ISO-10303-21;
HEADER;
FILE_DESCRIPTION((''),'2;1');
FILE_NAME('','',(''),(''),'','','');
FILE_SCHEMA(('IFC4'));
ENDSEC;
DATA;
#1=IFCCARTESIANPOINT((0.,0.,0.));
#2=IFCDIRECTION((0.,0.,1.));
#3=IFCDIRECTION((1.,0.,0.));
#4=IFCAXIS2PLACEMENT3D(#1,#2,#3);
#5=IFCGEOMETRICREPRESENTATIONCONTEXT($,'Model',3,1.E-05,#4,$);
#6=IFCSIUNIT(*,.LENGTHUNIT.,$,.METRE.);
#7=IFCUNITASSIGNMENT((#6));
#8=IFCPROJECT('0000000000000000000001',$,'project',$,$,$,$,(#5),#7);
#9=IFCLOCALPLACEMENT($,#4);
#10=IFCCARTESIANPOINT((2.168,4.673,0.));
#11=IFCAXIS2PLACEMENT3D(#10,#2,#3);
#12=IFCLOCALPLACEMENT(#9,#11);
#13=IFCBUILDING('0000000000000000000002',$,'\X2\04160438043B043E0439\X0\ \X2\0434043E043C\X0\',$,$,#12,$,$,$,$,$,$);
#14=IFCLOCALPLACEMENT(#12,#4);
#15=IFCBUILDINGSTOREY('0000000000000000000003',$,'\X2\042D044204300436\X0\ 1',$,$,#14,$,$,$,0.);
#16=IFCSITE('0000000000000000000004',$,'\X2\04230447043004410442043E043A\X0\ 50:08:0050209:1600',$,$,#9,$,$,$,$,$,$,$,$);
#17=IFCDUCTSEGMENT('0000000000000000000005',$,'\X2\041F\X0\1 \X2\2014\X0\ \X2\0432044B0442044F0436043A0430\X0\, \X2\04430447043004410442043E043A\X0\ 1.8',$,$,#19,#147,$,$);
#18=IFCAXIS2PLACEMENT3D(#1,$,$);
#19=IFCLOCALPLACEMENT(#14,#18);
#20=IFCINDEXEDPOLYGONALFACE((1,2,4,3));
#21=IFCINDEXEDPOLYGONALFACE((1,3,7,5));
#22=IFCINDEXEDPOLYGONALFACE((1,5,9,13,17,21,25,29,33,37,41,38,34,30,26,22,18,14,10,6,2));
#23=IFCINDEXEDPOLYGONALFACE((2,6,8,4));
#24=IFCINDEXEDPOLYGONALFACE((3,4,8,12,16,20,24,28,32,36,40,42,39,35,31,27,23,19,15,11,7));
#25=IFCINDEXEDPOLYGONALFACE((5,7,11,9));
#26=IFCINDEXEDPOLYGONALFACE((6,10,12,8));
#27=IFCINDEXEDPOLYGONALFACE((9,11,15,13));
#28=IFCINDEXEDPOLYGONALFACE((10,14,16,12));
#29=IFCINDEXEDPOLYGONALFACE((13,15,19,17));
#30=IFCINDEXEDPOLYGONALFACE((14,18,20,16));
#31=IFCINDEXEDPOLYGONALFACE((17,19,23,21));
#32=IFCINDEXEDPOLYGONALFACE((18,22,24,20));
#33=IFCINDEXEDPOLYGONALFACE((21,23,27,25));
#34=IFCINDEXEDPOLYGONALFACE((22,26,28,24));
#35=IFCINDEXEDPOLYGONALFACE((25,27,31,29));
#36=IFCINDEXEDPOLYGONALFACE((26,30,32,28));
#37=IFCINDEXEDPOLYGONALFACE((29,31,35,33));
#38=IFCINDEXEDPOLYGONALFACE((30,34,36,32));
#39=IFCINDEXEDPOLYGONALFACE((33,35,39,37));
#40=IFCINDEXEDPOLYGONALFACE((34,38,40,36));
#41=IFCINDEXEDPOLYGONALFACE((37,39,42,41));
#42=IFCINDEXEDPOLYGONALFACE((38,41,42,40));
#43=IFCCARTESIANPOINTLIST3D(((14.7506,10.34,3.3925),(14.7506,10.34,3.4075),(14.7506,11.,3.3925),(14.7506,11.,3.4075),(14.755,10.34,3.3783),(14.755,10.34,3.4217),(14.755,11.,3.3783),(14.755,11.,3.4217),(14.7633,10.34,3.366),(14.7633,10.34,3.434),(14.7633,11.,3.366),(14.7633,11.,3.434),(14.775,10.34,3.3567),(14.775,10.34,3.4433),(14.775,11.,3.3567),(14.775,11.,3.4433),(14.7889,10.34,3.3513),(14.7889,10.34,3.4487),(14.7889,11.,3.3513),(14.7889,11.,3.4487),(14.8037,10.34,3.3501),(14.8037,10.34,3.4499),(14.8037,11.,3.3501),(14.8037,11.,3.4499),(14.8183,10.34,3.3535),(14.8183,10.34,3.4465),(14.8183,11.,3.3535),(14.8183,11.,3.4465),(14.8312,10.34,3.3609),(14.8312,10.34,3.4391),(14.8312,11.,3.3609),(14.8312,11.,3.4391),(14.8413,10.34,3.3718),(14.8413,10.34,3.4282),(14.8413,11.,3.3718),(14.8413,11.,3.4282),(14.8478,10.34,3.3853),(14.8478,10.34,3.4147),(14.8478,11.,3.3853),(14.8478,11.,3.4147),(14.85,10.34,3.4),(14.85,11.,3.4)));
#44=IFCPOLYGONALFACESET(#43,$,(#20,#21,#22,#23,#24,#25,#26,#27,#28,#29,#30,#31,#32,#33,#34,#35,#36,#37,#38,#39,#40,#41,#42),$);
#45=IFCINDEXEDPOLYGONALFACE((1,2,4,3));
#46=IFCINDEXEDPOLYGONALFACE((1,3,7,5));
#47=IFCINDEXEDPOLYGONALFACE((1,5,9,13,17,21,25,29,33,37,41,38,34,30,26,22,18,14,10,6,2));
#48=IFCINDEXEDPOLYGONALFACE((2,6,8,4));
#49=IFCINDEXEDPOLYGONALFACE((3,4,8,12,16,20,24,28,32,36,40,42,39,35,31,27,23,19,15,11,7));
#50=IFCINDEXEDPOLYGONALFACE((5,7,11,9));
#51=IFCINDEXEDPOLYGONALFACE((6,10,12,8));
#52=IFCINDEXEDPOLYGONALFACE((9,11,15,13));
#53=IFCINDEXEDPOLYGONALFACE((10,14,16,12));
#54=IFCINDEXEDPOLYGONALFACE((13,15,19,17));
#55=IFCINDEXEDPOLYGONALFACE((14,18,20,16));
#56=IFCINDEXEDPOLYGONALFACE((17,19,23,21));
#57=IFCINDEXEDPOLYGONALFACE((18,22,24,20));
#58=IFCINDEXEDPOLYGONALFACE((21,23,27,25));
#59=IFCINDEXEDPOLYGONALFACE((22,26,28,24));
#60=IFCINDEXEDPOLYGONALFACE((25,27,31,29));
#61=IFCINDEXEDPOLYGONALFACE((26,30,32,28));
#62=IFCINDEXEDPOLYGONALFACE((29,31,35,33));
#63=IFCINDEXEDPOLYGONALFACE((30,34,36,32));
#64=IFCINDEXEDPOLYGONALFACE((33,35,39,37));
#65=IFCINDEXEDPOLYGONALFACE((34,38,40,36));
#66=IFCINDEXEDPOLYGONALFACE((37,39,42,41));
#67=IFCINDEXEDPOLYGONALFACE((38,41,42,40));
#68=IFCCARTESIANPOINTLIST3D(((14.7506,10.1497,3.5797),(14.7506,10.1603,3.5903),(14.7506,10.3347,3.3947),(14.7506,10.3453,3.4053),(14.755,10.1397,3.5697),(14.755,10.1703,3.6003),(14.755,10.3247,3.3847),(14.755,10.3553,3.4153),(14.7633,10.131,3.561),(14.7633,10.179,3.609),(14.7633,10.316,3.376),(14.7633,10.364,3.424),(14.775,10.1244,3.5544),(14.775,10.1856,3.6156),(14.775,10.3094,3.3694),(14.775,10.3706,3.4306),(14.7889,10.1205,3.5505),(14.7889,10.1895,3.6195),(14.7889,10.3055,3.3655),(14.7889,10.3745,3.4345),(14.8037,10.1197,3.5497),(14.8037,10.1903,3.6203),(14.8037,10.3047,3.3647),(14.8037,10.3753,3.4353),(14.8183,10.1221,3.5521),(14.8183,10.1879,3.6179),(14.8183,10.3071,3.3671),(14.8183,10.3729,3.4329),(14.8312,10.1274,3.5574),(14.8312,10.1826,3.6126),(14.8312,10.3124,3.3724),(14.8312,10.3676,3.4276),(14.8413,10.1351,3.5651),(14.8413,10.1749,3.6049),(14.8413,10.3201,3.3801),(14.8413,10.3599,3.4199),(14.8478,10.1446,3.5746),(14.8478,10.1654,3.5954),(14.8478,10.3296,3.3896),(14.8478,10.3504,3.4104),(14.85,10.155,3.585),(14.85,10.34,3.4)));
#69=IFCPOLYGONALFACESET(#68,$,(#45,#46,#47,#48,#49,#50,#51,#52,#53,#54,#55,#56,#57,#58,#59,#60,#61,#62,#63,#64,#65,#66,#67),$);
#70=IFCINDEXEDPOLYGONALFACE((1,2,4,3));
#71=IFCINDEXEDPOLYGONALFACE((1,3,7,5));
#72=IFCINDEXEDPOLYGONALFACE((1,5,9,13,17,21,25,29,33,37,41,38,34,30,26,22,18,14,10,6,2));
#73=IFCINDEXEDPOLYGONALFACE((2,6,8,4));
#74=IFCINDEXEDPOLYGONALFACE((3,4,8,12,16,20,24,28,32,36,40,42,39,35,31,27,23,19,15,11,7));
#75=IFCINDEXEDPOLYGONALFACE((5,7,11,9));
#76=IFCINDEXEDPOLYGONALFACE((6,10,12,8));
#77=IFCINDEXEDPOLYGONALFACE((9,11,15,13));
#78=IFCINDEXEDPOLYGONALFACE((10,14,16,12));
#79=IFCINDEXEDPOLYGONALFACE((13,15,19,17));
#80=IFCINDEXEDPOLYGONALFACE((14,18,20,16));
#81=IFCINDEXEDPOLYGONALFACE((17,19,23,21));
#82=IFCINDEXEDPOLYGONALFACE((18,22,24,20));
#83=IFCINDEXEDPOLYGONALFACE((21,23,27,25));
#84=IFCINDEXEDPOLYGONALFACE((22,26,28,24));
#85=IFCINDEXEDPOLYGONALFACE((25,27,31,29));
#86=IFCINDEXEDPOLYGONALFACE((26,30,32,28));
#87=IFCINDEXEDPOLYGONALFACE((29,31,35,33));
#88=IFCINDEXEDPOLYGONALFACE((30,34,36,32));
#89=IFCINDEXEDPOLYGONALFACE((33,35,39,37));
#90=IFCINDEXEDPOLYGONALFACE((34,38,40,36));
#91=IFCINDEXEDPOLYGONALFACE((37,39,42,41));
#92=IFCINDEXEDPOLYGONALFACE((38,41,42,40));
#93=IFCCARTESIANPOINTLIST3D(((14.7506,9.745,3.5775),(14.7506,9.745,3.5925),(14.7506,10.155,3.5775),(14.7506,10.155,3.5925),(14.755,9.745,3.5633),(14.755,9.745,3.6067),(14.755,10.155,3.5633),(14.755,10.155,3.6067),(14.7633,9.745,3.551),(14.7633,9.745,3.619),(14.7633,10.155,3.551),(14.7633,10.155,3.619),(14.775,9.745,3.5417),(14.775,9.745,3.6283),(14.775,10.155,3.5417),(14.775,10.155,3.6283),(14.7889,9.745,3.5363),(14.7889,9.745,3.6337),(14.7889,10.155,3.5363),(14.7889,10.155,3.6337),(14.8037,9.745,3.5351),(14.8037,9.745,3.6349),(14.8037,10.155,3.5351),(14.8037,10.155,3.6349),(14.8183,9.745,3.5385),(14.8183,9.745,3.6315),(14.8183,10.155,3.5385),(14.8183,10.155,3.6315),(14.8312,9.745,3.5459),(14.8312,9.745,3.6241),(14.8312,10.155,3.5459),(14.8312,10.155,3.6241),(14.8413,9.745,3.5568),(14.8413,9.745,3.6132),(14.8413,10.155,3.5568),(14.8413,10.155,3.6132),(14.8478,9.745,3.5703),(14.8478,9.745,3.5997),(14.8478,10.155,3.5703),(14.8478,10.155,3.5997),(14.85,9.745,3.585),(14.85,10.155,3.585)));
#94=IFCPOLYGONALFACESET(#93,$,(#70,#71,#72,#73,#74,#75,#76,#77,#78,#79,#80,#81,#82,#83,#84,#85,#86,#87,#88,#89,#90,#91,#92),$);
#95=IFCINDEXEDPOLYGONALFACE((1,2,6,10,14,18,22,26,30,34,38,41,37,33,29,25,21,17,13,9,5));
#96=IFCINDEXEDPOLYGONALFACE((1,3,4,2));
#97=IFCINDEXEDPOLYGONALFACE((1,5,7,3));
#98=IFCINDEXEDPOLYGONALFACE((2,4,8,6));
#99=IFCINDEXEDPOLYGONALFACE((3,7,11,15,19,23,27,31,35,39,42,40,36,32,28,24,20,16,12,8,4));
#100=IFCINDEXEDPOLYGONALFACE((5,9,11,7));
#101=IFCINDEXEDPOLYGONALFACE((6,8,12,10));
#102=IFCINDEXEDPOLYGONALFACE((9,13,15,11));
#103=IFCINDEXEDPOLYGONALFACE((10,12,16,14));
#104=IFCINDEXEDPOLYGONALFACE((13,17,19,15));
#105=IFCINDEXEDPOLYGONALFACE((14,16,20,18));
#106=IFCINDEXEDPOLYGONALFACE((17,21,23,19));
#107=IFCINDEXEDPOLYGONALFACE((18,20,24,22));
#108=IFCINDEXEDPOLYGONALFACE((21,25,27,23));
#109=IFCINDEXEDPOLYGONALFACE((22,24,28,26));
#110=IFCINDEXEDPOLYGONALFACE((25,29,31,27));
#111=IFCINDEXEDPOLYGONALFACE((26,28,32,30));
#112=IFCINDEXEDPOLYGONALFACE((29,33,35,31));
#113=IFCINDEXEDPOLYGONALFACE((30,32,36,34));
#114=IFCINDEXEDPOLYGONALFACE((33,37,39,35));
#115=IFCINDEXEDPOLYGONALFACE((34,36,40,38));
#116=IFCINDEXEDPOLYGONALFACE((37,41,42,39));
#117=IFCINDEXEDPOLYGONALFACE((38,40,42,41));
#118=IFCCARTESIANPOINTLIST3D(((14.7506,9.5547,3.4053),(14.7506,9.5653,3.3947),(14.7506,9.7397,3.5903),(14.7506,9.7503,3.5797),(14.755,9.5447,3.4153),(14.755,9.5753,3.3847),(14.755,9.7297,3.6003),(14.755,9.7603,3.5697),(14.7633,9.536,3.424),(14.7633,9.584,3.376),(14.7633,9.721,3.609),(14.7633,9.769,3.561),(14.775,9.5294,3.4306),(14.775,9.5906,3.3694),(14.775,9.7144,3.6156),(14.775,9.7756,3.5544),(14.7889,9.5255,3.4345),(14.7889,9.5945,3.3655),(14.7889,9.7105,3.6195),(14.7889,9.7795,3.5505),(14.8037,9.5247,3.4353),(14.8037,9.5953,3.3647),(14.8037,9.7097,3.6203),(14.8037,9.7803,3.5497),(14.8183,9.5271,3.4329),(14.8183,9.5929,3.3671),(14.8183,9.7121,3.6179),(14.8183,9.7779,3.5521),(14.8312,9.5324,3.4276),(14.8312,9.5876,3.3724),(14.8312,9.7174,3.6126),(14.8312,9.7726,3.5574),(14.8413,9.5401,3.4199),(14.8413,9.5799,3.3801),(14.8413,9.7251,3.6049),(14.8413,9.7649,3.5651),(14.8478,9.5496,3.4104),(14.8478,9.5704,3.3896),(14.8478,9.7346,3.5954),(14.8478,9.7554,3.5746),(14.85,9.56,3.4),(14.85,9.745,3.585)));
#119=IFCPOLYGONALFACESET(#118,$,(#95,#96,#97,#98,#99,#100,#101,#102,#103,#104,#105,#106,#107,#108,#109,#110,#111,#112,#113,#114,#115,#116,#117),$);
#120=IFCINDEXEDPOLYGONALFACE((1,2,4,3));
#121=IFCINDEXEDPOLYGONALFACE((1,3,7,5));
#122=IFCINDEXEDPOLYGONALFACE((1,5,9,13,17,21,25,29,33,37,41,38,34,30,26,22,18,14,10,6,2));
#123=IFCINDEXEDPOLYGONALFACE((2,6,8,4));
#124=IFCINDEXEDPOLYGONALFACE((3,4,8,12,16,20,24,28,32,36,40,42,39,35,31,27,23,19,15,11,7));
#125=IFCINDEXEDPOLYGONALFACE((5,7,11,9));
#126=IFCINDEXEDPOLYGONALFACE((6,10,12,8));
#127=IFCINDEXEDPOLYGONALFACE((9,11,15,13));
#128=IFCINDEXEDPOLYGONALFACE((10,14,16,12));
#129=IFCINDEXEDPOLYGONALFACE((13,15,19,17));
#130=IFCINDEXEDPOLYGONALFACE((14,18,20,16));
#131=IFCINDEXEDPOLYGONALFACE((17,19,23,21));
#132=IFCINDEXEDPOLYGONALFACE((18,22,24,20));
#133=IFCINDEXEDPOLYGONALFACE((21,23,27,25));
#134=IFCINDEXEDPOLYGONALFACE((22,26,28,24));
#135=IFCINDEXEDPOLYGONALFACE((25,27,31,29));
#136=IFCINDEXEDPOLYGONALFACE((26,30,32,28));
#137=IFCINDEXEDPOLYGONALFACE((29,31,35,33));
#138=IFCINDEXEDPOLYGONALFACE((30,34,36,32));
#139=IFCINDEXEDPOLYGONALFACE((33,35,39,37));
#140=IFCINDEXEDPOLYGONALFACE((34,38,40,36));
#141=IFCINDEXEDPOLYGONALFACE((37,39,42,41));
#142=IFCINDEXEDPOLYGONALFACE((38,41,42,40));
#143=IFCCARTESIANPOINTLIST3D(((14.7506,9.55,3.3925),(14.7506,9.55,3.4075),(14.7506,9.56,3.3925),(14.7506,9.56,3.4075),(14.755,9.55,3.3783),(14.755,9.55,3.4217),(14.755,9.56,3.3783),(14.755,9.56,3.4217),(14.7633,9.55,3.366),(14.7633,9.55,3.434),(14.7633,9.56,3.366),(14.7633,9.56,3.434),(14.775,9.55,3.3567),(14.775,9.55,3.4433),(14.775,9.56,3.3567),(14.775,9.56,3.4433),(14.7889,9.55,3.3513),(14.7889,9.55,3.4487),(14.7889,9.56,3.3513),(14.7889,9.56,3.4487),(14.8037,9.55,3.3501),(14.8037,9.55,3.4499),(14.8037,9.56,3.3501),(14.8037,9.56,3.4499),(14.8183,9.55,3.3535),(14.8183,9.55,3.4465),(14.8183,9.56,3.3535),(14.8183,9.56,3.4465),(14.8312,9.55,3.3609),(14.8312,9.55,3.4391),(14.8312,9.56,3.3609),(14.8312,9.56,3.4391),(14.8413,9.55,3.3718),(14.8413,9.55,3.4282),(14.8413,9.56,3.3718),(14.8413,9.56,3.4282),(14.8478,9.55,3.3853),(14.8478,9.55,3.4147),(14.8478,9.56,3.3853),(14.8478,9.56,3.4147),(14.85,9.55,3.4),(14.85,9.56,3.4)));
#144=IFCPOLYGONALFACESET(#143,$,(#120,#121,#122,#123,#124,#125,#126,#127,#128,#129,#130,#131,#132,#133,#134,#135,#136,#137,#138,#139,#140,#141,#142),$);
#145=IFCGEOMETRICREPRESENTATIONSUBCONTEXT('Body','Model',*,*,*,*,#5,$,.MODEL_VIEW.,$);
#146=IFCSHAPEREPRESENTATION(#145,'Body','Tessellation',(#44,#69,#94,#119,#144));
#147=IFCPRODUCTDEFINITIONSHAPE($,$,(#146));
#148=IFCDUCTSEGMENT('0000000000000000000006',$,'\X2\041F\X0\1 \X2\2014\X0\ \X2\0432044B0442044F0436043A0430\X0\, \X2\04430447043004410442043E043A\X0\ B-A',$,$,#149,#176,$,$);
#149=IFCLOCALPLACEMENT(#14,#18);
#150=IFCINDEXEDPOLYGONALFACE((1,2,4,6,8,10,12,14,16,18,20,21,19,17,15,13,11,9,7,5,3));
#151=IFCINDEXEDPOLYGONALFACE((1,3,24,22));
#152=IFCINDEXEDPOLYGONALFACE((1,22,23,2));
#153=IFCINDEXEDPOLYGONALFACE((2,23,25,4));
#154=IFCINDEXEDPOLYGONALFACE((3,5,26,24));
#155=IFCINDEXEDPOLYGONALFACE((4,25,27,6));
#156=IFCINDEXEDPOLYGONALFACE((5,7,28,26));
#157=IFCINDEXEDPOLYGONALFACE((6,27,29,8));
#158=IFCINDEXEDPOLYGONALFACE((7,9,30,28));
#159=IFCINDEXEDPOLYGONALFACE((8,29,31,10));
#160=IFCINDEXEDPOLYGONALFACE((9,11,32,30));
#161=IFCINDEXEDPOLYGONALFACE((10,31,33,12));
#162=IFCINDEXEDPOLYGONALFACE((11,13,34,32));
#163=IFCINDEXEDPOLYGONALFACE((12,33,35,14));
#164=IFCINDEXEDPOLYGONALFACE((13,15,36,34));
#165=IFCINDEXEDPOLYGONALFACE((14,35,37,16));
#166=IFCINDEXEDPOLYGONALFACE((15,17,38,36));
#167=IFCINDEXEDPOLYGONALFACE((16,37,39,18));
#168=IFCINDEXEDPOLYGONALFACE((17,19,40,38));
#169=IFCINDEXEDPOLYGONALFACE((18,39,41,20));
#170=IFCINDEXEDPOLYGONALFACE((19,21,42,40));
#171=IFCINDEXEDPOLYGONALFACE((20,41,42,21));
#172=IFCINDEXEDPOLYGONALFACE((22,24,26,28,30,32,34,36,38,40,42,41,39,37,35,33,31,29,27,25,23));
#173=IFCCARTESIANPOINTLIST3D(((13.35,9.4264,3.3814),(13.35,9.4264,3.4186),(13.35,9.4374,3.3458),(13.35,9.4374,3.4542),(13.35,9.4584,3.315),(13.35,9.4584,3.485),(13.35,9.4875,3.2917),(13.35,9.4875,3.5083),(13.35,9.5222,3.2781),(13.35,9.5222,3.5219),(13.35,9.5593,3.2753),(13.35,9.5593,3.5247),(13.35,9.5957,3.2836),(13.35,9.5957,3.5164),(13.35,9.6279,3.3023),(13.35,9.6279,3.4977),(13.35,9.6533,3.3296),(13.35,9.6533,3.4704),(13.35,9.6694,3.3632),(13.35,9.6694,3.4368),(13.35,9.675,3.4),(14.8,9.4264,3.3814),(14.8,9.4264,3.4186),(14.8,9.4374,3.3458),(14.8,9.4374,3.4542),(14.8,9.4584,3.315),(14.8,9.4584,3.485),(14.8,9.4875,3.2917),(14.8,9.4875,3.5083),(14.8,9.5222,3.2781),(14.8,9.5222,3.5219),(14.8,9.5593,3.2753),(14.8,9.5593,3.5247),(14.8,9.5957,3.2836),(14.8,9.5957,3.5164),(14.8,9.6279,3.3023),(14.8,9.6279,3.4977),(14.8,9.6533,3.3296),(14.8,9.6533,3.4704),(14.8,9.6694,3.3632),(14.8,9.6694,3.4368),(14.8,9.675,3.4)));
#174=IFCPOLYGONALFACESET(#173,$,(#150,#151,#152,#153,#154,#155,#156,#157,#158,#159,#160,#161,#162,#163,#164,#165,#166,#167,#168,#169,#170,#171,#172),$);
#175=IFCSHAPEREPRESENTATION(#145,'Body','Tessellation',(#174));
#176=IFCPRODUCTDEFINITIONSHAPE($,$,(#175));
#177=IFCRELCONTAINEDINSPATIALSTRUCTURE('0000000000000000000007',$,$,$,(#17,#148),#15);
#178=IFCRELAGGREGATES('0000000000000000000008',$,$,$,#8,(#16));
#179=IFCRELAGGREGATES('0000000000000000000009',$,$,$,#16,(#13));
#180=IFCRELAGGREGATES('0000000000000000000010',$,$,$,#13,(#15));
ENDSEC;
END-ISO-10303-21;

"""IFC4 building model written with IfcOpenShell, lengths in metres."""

from ifc_helpers import new_model, si_unit, frame, origin_with_axes, origin_2d, place, context, subcontext, project, spatial, circle, extrude, element, save


model = new_model("IFC4")

# Units and contexts
model_context = context("Model", 3, precision=1e-05, world=origin_with_axes())
body_context = subcontext(model_context, "Body", "Model", "MODEL_VIEW")
ifc_project = project(units=[si_unit("LENGTHUNIT", "METRE")], contexts=[model_context])

# Site, building, storey
site_placement = place(None, origin_with_axes())
site = spatial("IfcSite", under=ifc_project, at=site_placement, Name="Участок 50:08:0050209:1600")
building_placement = place(site_placement, frame((2.168, 4.673, 0.0), z_axis=(0.0, 0.0, 1.0), x_axis=(1.0, 0.0, 0.0)))
building = spatial("IfcBuilding", under=site, at=building_placement, Name="Жилой дом")
storey_placement = place(building_placement, origin_with_axes())
storey = spatial("IfcBuildingStorey", under=building, at=storey_placement, Name="Этаж 1", Elevation=0.0)

# Duct segments
duct_segment_1_placement = place(storey_placement, origin_with_axes())
element("IfcDuctSegment", 1, at=duct_segment_1_placement, inside=storey, Name="П1 — вытяжка, участок 1.8", context=body_context, shape_type="SweptSolid", body=[
    extrude(circle(Radius=0.05, at=origin_2d()), frame((14.8, 11.0, 3.4), z_axis=(0.0, -1.0, 0.0), x_axis=(1.0, 0.0, 0.0)), (0.0, 0.0, 1.0), 0.66),
    extrude(circle(Radius=0.05, at=origin_2d()), frame((14.8, 10.34, 3.4), z_axis=(0.0, -0.707107, 0.707107), x_axis=(1.0, 0.0, 0.0)), (0.0, 0.0, 1.0), 0.2616),
    extrude(circle(Radius=0.05, at=origin_2d()), frame((14.8, 10.155, 3.585), z_axis=(0.0, -1.0, 0.0), x_axis=(1.0, 0.0, 0.0)), (0.0, 0.0, 1.0), 0.41),
    extrude(circle(Radius=0.05, at=origin_2d()), frame((14.8, 9.745, 3.585), z_axis=(0.0, -0.707107, -0.707107), x_axis=(1.0, 0.0, 0.0)), (0.0, 0.0, 1.0), 0.2616),
    extrude(circle(Radius=0.05, at=origin_2d()), frame((14.8, 9.56, 3.4), z_axis=(0.0, -1.0, 0.0), x_axis=(1.0, 0.0, 0.0)), (0.0, 0.0, 1.0), 0.01),
])
duct_segment_2_placement = place(storey_placement, origin_with_axes())
element("IfcDuctSegment", 2, at=duct_segment_2_placement, inside=storey, Name="П1 — вытяжка, участок B-A", context=body_context, shape_type="SweptSolid", body=[
    extrude(circle(Radius=0.125, at=origin_2d()), frame((13.35, 9.55, 3.4), z_axis=(1.0, 0.0, 0.0), x_axis=(0.0, 1.0, 0.0)), (0.0, 0.0, 1.0), 1.45),
])

save(model, "model.ifc")
